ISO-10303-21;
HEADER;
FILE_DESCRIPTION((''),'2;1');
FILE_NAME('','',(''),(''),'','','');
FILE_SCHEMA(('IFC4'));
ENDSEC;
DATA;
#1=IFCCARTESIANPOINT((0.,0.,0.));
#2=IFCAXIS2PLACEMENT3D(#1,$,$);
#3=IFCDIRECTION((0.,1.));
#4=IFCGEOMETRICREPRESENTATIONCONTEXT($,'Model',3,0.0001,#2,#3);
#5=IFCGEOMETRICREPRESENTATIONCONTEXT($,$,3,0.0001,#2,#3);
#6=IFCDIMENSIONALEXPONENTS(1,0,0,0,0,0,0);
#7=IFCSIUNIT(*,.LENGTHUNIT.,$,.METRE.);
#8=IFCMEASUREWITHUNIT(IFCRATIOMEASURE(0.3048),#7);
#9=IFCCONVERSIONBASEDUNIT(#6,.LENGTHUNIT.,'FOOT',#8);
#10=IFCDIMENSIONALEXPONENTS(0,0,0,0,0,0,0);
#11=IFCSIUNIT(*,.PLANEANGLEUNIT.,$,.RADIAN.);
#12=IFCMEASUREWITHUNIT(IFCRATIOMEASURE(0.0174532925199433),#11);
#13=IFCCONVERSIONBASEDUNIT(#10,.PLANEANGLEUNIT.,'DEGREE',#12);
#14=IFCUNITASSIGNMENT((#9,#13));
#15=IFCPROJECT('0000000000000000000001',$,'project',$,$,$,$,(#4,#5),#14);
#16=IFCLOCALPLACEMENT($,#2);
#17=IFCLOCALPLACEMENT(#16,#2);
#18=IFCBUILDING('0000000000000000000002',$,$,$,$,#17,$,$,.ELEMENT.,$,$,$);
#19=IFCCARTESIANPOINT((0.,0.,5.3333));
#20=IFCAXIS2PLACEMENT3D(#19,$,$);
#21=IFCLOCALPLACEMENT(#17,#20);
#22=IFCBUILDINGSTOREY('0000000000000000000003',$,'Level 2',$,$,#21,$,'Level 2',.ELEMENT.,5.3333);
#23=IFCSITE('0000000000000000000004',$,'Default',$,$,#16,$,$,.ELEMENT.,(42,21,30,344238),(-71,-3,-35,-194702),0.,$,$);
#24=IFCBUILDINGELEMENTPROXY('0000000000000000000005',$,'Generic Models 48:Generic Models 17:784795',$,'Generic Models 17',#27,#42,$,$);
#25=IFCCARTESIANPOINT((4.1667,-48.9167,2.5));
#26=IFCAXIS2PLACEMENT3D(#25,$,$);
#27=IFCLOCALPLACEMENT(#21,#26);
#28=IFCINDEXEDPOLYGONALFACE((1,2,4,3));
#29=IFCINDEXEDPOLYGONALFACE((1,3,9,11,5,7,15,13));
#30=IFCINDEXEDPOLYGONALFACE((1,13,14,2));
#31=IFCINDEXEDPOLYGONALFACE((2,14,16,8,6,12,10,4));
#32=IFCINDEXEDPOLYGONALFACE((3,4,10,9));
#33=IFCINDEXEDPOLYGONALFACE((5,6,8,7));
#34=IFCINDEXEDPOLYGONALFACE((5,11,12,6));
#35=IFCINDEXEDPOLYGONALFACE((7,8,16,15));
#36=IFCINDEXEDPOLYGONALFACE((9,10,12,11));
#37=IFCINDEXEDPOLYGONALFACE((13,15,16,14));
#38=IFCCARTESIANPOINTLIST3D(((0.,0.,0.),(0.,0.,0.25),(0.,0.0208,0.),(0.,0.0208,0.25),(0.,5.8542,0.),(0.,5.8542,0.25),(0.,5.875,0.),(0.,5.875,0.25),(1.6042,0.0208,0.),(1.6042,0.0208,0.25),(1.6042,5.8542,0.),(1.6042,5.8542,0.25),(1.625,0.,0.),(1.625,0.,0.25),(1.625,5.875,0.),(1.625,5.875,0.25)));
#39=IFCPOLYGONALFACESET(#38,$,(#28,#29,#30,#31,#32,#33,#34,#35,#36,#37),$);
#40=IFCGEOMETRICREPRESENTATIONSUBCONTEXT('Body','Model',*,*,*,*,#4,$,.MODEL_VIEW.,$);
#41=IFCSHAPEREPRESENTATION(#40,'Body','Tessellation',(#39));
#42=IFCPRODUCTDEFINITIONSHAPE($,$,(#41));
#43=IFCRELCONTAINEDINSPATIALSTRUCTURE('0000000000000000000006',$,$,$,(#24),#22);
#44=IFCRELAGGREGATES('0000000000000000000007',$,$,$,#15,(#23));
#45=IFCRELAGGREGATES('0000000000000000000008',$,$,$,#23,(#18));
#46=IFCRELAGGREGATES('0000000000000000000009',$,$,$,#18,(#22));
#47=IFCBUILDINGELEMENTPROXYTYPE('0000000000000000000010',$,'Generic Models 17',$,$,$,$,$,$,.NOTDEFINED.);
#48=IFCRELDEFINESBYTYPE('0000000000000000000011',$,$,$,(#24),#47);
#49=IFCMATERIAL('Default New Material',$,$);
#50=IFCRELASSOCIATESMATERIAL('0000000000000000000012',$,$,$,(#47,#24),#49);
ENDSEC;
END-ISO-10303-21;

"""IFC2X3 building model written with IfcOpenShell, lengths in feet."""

from ifc_helpers import new_model, entity, si_unit, converted_unit, direction, frame, origin, place, context, subcontext, project, spatial, polyline, outline, extrude, source, transform, mapped, material, type_object, type_shapes, element, save


model = new_model("IFC2X3")

# Units and contexts
model_context = context("Model", 3, precision=0.0001, world=origin(), true_north=direction((0.0, 1.0)))
context_of_model = context(None, 3, precision=0.0001, world=origin(), true_north=direction((0.0, 1.0)))
body_context = subcontext(model_context, "Body", "Model", "MODEL_VIEW")
ifc_project = project(units=[converted_unit("LENGTHUNIT", "FOOT", entity("IfcRatioMeasure", 0.3048), si_unit("LENGTHUNIT", "METRE"), dimensions=[1, 0, 0, 0, 0, 0, 0]), converted_unit("PLANEANGLEUNIT", "DEGREE", entity("IfcRatioMeasure", 0.0174532925199433), si_unit("PLANEANGLEUNIT", "RADIAN"), dimensions=[0, 0, 0, 0, 0, 0, 0])], contexts=[model_context, context_of_model])

# Site, building, storey
site_placement = place(None, origin())
site = spatial("IfcSite", under=ifc_project, at=site_placement, Name="Default", CompositionType="ELEMENT", RefLatitude=(42, 21, 30, 344238), RefLongitude=(-71, -3, -35, -194702), RefElevation=0.0)
building_placement = place(site_placement, origin())
building = spatial("IfcBuilding", under=site, at=building_placement, CompositionType="ELEMENT")
storey_placement = place(building_placement, frame((0.0, 0.0, 5.3333)))
storey = spatial("IfcBuildingStorey", under=building, at=storey_placement, Name="Level 2", LongName="Level 2", CompositionType="ELEMENT", Elevation=5.3333)

# Shared definitions
ifc_material = material(Name="Default New Material")

# Building element proxy
building_element_proxy_type_1 = type_object("IfcBuildingElementProxyType", Name="Generic Models 17", PredefinedType="NOTDEFINED", material=ifc_material)
shared_shape_1 = source(origin(), body_context, "Body", "SweptSolid", [
    extrude(outline(polyline([(-2.9375, -0.8177), (2.9375, -0.8177), (2.9375, 0.8073), (2.9167, 0.8073), (2.9167, -0.7969), (-2.9167, -0.7969), (-2.9167, 0.8073), (-2.9375, 0.8073), (-2.9375, -0.8177)])), frame((0.8073, 2.9375, 0.0), z_axis=(0.0, 0.0, 1.0), x_axis=(0.0, 1.0, 0.0)), (0.0, 0.0, 1.0), 0.25),
])
type_shapes(building_element_proxy_type_1, [shared_shape_1])
proxy_1_placement = place(storey_placement, frame((4.1667, -48.9167, 2.5)))
element("IfcBuildingElementProxy", 1, at=proxy_1_placement, inside=storey, type_object=building_element_proxy_type_1, material=ifc_material, Name="Generic Models 48:Generic Models 17:784795", ObjectType="Generic Models 17", context=body_context, shape_type="MappedRepresentation", body=[
    mapped(shared_shape_1, transform((0.0, 0.0, 0.0), scale=1.0)),
])

save(model, "model.ifc")
